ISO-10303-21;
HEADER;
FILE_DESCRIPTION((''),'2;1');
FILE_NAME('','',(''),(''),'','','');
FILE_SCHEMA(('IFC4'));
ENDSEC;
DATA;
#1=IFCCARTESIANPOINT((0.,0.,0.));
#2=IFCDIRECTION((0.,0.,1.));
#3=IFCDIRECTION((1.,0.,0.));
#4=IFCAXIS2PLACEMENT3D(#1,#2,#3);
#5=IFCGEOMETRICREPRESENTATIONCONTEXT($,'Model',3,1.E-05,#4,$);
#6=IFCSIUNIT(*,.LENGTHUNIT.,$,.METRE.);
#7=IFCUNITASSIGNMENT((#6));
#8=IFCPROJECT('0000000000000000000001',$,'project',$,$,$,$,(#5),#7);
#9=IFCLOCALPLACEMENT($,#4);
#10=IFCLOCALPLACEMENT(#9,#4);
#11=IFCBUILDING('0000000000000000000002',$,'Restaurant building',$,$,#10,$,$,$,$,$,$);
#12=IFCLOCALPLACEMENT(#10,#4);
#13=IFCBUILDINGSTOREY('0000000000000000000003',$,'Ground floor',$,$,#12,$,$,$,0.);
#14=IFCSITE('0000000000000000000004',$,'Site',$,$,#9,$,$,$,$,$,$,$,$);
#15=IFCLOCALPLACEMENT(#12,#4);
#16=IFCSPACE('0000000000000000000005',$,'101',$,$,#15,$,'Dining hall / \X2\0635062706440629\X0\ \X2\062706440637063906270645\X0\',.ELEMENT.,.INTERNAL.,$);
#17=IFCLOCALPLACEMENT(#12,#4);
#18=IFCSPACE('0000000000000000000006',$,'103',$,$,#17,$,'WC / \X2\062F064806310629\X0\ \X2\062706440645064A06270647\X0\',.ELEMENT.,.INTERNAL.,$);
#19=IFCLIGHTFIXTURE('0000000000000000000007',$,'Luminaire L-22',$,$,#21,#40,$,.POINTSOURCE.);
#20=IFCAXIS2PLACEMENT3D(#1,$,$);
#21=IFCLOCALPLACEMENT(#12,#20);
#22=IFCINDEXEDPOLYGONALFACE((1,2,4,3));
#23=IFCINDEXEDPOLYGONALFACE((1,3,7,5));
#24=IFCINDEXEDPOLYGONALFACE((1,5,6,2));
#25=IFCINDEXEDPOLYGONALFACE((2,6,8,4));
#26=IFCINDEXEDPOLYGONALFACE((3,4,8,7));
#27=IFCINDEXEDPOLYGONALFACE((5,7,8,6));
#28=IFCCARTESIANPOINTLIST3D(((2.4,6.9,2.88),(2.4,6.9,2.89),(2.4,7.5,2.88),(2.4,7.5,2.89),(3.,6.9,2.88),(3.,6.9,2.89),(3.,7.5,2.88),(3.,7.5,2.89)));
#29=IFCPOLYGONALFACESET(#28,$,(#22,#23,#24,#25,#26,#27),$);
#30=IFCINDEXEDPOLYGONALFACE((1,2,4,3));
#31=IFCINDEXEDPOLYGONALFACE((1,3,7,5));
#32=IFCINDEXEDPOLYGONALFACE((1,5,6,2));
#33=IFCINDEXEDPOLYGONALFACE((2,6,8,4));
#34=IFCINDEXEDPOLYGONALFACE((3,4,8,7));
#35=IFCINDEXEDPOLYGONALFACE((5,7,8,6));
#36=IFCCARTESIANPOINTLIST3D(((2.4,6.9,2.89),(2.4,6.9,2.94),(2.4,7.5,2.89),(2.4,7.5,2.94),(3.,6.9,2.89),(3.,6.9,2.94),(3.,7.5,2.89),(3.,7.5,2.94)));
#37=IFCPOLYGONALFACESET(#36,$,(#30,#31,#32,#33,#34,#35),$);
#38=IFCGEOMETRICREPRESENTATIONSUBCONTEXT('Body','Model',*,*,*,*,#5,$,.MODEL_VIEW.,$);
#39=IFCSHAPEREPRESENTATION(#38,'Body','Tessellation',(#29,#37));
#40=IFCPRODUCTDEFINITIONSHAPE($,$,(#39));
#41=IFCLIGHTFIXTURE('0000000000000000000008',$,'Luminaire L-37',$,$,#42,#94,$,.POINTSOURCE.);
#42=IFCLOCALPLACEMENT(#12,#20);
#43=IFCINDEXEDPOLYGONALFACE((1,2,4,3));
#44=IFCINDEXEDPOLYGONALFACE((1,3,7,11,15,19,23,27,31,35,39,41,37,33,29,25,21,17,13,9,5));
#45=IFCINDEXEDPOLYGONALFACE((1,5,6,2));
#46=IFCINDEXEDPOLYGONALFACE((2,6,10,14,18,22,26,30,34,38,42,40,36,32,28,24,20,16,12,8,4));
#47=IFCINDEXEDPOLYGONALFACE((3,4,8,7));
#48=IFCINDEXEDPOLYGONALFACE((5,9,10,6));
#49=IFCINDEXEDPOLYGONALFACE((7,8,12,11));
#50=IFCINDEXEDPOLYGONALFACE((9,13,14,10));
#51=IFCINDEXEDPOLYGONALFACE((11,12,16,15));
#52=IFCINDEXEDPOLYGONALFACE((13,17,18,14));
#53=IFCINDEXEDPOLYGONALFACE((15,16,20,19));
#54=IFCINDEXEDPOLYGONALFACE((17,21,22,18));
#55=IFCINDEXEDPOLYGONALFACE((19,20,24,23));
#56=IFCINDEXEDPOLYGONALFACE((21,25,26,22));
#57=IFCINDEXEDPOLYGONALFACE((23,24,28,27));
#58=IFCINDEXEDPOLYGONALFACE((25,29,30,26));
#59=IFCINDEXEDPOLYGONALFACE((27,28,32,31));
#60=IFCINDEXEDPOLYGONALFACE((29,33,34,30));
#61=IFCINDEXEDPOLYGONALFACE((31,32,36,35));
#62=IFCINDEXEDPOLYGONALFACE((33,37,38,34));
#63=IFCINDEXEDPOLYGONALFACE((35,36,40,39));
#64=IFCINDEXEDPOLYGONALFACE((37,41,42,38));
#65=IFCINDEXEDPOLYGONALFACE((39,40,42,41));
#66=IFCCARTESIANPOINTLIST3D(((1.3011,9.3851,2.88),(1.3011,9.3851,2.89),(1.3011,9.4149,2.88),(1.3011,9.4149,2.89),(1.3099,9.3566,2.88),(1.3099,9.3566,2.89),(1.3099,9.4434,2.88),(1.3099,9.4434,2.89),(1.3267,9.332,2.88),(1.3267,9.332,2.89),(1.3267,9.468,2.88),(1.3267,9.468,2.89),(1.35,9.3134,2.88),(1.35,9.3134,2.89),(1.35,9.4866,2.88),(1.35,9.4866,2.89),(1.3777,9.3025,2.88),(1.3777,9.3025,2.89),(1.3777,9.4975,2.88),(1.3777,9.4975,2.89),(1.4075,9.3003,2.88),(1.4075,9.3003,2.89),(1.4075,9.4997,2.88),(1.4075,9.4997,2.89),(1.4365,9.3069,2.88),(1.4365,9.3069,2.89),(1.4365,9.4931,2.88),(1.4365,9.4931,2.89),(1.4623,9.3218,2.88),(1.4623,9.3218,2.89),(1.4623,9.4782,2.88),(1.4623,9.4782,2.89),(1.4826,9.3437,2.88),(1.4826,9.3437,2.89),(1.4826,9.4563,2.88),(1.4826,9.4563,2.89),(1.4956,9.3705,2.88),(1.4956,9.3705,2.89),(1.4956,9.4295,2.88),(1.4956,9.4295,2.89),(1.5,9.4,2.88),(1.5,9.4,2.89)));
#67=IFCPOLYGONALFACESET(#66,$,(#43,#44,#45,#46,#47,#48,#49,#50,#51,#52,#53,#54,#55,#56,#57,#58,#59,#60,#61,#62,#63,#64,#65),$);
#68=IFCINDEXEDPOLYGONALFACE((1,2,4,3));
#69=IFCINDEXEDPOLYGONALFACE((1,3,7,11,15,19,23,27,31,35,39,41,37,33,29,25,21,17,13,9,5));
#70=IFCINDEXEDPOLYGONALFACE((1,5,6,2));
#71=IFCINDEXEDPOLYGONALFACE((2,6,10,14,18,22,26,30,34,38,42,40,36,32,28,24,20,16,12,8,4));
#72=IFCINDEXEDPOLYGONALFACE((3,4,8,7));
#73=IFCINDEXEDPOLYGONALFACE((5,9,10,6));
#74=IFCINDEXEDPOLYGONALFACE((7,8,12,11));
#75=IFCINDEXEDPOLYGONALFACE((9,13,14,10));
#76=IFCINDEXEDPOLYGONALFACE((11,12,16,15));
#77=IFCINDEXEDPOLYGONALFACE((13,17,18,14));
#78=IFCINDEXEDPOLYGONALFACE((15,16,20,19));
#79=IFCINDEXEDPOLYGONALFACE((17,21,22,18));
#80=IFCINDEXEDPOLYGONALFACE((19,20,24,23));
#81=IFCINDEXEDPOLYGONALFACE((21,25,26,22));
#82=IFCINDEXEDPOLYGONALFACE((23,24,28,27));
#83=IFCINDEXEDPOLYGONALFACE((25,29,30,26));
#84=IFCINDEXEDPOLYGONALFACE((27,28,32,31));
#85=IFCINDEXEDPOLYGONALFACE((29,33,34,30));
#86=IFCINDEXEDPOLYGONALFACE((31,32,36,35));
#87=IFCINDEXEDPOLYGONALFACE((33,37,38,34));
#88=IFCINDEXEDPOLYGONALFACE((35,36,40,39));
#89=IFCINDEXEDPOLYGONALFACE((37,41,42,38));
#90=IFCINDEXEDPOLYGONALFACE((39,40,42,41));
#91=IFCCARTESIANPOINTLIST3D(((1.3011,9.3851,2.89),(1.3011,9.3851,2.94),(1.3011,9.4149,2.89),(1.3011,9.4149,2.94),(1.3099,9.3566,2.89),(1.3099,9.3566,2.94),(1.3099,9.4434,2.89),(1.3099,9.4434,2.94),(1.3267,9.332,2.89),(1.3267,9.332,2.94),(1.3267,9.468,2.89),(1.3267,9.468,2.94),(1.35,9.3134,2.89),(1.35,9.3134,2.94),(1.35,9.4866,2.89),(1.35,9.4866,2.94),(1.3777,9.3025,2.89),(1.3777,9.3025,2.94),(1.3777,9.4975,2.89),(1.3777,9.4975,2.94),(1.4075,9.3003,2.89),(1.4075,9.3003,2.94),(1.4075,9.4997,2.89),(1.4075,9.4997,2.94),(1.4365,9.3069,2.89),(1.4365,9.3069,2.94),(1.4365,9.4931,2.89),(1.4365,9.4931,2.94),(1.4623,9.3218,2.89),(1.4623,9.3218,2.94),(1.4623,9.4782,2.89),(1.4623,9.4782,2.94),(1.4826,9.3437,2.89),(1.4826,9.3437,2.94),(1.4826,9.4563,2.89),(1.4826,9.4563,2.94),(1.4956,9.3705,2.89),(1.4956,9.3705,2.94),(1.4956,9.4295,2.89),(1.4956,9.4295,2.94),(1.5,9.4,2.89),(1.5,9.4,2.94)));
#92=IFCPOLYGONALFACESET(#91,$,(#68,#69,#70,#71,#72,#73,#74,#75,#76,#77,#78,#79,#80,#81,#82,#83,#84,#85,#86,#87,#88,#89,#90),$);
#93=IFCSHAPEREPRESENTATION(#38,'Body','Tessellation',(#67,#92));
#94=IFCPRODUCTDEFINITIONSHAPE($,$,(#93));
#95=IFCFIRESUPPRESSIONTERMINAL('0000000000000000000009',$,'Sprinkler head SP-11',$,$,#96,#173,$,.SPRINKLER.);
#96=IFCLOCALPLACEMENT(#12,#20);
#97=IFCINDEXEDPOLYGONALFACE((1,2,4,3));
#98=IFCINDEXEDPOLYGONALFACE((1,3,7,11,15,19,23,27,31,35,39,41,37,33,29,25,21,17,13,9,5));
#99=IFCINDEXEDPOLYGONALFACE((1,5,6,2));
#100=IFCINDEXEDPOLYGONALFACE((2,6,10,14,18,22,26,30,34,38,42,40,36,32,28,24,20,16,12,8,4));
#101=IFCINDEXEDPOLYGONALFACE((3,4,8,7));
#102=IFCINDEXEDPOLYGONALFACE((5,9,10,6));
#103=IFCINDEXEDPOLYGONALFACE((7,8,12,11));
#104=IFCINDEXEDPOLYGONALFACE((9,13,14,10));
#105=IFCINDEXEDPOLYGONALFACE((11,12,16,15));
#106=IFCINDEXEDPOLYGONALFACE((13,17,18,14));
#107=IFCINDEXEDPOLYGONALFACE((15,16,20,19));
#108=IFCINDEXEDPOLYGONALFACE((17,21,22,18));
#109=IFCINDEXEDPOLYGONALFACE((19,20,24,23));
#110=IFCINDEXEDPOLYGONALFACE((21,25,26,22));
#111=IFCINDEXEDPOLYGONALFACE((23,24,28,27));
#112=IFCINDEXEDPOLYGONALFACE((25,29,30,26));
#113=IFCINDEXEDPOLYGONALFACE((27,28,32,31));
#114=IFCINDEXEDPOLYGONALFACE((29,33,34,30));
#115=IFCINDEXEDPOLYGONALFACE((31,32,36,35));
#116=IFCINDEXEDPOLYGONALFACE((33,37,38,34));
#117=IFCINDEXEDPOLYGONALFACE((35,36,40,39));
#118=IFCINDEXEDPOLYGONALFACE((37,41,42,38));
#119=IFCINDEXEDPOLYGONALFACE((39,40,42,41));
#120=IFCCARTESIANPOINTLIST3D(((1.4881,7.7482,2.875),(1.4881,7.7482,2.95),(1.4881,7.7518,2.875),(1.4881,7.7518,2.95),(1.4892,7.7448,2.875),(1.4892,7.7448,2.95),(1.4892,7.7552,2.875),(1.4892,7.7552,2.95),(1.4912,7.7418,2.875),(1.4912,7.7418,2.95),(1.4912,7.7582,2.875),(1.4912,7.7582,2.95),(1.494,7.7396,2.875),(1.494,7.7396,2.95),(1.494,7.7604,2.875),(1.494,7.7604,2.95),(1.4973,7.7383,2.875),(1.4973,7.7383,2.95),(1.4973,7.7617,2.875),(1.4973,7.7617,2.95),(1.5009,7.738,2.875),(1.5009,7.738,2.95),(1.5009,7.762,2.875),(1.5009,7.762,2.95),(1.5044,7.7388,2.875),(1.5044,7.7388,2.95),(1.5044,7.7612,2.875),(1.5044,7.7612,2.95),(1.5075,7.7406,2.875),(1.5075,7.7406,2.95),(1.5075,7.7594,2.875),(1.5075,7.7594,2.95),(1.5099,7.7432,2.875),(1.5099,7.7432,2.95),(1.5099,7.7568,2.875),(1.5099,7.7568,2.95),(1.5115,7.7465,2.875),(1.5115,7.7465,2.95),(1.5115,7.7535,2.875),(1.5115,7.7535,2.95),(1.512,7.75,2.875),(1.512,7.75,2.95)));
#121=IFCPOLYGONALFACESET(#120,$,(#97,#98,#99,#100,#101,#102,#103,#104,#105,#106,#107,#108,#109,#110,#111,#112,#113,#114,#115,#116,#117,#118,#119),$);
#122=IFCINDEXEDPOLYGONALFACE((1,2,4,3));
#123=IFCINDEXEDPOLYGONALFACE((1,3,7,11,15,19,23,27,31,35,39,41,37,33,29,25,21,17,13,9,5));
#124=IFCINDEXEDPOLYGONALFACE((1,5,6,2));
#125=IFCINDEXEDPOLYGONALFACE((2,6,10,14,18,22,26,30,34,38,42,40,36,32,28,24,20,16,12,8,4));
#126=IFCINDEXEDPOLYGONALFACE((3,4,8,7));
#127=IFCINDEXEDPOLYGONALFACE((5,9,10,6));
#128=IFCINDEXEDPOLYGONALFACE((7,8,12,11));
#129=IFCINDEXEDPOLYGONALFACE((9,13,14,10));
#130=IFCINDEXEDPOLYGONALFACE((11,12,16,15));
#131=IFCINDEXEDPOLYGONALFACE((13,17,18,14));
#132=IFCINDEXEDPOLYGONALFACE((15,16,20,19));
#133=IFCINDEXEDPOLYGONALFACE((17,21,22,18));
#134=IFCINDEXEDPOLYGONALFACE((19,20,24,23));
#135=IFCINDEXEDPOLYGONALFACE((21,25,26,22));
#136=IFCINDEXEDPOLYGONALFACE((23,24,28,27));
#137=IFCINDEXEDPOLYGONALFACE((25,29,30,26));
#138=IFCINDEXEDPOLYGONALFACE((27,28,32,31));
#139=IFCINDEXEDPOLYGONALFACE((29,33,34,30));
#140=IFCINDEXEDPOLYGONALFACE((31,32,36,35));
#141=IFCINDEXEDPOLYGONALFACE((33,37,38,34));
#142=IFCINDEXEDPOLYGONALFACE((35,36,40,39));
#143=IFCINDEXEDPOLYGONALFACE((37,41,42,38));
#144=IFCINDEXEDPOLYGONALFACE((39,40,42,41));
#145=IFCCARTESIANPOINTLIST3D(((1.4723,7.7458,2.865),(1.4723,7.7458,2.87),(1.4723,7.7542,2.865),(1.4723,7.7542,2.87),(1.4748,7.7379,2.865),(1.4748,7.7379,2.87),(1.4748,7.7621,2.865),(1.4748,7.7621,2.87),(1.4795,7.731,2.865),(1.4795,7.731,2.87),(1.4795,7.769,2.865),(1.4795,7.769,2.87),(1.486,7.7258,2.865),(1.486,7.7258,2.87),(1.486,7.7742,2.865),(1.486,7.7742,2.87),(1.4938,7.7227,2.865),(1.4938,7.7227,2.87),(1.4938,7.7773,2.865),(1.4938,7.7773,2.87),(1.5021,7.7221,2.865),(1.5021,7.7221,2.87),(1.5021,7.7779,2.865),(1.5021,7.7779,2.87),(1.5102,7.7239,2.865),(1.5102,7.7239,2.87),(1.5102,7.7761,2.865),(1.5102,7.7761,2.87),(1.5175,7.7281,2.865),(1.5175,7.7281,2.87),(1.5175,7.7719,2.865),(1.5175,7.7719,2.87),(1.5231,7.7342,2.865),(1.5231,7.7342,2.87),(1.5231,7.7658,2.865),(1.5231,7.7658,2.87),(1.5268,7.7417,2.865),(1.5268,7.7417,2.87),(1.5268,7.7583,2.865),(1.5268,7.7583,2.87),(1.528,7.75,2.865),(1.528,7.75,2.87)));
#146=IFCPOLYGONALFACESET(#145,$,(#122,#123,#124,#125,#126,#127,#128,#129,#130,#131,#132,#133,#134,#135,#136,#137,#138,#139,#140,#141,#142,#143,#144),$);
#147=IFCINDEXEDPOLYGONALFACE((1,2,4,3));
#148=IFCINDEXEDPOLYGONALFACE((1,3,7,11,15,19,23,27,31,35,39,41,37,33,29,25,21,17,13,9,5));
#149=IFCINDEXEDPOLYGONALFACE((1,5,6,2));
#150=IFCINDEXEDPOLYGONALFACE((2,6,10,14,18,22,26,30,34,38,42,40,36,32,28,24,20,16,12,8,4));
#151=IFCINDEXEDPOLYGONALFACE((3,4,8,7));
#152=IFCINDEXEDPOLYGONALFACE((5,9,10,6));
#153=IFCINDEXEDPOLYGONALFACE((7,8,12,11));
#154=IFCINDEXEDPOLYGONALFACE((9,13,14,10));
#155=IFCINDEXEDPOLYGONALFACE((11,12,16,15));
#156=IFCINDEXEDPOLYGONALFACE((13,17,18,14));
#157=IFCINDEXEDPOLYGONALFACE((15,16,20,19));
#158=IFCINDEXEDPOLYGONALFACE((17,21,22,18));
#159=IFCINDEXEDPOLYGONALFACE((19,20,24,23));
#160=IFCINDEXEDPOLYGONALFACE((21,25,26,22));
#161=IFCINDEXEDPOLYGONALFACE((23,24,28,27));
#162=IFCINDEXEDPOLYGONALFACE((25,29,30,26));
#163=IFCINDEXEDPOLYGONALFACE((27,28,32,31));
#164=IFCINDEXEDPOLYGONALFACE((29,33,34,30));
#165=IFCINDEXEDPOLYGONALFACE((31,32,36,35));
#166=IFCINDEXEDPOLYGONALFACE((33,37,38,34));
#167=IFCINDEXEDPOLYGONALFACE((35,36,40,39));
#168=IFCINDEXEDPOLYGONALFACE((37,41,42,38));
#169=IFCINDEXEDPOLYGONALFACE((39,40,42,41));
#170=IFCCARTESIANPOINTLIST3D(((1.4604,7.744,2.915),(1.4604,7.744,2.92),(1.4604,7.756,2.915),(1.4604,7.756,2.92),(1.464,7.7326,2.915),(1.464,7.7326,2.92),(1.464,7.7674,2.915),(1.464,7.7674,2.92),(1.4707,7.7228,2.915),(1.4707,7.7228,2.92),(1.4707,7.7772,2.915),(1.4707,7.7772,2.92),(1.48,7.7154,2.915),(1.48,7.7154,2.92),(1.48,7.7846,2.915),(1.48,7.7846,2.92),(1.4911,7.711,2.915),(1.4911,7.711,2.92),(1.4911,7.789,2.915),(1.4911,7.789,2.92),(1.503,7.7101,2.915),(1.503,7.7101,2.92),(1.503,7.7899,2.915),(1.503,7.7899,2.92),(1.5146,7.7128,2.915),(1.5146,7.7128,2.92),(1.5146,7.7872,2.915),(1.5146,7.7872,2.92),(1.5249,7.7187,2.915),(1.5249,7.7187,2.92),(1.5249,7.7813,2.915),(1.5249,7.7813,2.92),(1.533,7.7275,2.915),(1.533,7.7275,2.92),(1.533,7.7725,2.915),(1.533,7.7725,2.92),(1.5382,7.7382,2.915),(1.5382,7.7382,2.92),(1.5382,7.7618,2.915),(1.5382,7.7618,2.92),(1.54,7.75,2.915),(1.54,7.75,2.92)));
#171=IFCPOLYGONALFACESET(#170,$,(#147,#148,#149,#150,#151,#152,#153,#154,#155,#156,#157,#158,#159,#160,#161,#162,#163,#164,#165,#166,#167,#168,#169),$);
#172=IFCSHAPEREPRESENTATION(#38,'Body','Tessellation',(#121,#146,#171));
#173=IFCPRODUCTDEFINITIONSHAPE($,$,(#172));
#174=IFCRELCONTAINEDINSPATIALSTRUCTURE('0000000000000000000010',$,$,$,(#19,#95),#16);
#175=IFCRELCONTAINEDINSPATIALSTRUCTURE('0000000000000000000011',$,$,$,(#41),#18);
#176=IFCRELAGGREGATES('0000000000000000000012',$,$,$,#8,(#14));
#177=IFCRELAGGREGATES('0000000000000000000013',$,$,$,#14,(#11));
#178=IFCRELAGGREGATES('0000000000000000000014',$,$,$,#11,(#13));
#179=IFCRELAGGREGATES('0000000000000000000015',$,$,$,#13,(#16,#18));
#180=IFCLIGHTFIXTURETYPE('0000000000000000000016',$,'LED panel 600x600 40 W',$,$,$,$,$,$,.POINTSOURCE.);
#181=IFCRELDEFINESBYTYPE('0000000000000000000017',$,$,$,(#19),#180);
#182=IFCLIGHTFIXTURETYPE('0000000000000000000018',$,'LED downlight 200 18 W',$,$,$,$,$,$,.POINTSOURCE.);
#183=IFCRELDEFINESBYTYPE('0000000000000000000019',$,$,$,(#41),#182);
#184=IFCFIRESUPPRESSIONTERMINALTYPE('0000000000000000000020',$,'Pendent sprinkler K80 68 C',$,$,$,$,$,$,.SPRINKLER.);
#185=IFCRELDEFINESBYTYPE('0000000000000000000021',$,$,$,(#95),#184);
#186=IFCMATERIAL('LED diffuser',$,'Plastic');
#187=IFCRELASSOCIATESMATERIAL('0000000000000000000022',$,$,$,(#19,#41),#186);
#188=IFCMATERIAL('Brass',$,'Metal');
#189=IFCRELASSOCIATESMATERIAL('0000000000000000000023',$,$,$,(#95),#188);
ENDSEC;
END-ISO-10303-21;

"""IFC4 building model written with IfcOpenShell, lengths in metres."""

from ifc_helpers import new_model, si_unit, frame, origin, origin_with_axes, origin_2d, place, context, subcontext, project, spatial, rectangle, circle, extrude, source, transform, mapped, material, type_object, type_shapes, element, save


model = new_model("IFC4")

# Units and contexts
model_context = context("Model", 3, precision=1e-05, world=origin_with_axes())
body_context = subcontext(model_context, "Body", "Model", "MODEL_VIEW")
ifc_project = project(units=[si_unit("LENGTHUNIT", "METRE")], contexts=[model_context])

# Site, building, storey, space
site_placement = place(None, origin_with_axes())
site = spatial("IfcSite", under=ifc_project, at=site_placement, Name="Site")
building_placement = place(site_placement, origin_with_axes())
building = spatial("IfcBuilding", under=site, at=building_placement, Name="Restaurant building")
storey_placement = place(building_placement, origin_with_axes())
storey = spatial("IfcBuildingStorey", under=building, at=storey_placement, Name="Ground floor", Elevation=0.0)
space_1_placement = place(storey_placement, origin_with_axes())
space_1 = spatial("IfcSpace", under=storey, at=space_1_placement, Name="101", LongName="Dining hall / صالة الطعام", CompositionType="ELEMENT", PredefinedType="INTERNAL")

# Light fixture
ifc_material_1 = material(Name="LED diffuser", Category="Plastic")
light_fixture_type_1 = type_object("IfcLightFixtureType", Name="LED panel 600x600 40 W", PredefinedType="POINTSOURCE")
shared_shape_1 = source(origin(), body_context, "Body", "SweptSolid", [
    extrude(rectangle(XDim=0.6, YDim=0.6, at=origin_2d()), frame((0.0, 0.0, -0.06)), (0.0, 0.0, 1.0), 0.01),
    extrude(rectangle(XDim=0.6, YDim=0.6, at=origin_2d()), frame((0.0, 0.0, -0.05)), (0.0, 0.0, 1.0), 0.05),
])
type_shapes(light_fixture_type_1, [shared_shape_1])
light_fixture_1_placement = place(storey_placement, frame((2.7, 7.2, 2.94)))
element("IfcLightFixture", 1, at=light_fixture_1_placement, inside=space_1, type_object=light_fixture_type_1, material=ifc_material_1, Name="Luminaire L-22", PredefinedType="POINTSOURCE", context=body_context, shape_type="MappedRepresentation", body=[
    mapped(shared_shape_1, transform((0.0, 0.0, 0.0))),
])

# Shared definitions
space_2_placement = place(storey_placement, origin_with_axes())
space_2 = spatial("IfcSpace", under=storey, at=space_2_placement, Name="103", LongName="WC / دورة المياه", CompositionType="ELEMENT", PredefinedType="INTERNAL")

# Light fixture
light_fixture_type_2 = type_object("IfcLightFixtureType", Name="LED downlight 200 18 W", PredefinedType="POINTSOURCE")
shared_shape_2 = source(origin(), body_context, "Body", "SweptSolid", [
    extrude(circle(Radius=0.1, at=origin_2d()), frame((0.0, 0.0, -0.06)), (0.0, 0.0, 1.0), 0.01),
    extrude(circle(Radius=0.1, at=origin_2d()), frame((0.0, 0.0, -0.05)), (0.0, 0.0, 1.0), 0.05),
])
type_shapes(light_fixture_type_2, [shared_shape_2])
light_fixture_2_placement = place(storey_placement, frame((1.4, 9.4, 2.94)))
element("IfcLightFixture", 2, at=light_fixture_2_placement, inside=space_2, type_object=light_fixture_type_2, material=ifc_material_1, Name="Luminaire L-37", PredefinedType="POINTSOURCE", context=body_context, shape_type="MappedRepresentation", body=[
    mapped(shared_shape_2, transform((0.0, 0.0, 0.0))),
])

# Fire suppression terminal
ifc_material_2 = material(Name="Brass", Category="Metal")
fire_suppression_terminal_type = type_object("IfcFireSuppressionTerminalType", Name="Pendent sprinkler K80 68 C", PredefinedType="SPRINKLER")
shared_shape_3 = source(origin(), body_context, "Body", "SweptSolid", [
    extrude(circle(Radius=0.012, at=origin_2d()), frame((0.0, 0.0, -0.075)), (0.0, 0.0, 1.0), 0.075),
    extrude(circle(Radius=0.028, at=origin_2d()), frame((0.0, 0.0, -0.085)), (0.0, 0.0, 1.0), 0.005),
    extrude(circle(Radius=0.04, at=origin_2d()), frame((0.0, 0.0, -0.035)), (0.0, 0.0, 1.0), 0.005),
])
type_shapes(fire_suppression_terminal_type, [shared_shape_3])
fire_suppression_terminal_1_placement = place(storey_placement, frame((1.5, 7.75, 2.95)))
element("IfcFireSuppressionTerminal", 3, at=fire_suppression_terminal_1_placement, inside=space_1, type_object=fire_suppression_terminal_type, material=ifc_material_2, Name="Sprinkler head SP-11", PredefinedType="SPRINKLER", context=body_context, shape_type="MappedRepresentation", body=[
    mapped(shared_shape_3, transform((0.0, 0.0, 0.0))),
])

save(model, "model.ifc")
